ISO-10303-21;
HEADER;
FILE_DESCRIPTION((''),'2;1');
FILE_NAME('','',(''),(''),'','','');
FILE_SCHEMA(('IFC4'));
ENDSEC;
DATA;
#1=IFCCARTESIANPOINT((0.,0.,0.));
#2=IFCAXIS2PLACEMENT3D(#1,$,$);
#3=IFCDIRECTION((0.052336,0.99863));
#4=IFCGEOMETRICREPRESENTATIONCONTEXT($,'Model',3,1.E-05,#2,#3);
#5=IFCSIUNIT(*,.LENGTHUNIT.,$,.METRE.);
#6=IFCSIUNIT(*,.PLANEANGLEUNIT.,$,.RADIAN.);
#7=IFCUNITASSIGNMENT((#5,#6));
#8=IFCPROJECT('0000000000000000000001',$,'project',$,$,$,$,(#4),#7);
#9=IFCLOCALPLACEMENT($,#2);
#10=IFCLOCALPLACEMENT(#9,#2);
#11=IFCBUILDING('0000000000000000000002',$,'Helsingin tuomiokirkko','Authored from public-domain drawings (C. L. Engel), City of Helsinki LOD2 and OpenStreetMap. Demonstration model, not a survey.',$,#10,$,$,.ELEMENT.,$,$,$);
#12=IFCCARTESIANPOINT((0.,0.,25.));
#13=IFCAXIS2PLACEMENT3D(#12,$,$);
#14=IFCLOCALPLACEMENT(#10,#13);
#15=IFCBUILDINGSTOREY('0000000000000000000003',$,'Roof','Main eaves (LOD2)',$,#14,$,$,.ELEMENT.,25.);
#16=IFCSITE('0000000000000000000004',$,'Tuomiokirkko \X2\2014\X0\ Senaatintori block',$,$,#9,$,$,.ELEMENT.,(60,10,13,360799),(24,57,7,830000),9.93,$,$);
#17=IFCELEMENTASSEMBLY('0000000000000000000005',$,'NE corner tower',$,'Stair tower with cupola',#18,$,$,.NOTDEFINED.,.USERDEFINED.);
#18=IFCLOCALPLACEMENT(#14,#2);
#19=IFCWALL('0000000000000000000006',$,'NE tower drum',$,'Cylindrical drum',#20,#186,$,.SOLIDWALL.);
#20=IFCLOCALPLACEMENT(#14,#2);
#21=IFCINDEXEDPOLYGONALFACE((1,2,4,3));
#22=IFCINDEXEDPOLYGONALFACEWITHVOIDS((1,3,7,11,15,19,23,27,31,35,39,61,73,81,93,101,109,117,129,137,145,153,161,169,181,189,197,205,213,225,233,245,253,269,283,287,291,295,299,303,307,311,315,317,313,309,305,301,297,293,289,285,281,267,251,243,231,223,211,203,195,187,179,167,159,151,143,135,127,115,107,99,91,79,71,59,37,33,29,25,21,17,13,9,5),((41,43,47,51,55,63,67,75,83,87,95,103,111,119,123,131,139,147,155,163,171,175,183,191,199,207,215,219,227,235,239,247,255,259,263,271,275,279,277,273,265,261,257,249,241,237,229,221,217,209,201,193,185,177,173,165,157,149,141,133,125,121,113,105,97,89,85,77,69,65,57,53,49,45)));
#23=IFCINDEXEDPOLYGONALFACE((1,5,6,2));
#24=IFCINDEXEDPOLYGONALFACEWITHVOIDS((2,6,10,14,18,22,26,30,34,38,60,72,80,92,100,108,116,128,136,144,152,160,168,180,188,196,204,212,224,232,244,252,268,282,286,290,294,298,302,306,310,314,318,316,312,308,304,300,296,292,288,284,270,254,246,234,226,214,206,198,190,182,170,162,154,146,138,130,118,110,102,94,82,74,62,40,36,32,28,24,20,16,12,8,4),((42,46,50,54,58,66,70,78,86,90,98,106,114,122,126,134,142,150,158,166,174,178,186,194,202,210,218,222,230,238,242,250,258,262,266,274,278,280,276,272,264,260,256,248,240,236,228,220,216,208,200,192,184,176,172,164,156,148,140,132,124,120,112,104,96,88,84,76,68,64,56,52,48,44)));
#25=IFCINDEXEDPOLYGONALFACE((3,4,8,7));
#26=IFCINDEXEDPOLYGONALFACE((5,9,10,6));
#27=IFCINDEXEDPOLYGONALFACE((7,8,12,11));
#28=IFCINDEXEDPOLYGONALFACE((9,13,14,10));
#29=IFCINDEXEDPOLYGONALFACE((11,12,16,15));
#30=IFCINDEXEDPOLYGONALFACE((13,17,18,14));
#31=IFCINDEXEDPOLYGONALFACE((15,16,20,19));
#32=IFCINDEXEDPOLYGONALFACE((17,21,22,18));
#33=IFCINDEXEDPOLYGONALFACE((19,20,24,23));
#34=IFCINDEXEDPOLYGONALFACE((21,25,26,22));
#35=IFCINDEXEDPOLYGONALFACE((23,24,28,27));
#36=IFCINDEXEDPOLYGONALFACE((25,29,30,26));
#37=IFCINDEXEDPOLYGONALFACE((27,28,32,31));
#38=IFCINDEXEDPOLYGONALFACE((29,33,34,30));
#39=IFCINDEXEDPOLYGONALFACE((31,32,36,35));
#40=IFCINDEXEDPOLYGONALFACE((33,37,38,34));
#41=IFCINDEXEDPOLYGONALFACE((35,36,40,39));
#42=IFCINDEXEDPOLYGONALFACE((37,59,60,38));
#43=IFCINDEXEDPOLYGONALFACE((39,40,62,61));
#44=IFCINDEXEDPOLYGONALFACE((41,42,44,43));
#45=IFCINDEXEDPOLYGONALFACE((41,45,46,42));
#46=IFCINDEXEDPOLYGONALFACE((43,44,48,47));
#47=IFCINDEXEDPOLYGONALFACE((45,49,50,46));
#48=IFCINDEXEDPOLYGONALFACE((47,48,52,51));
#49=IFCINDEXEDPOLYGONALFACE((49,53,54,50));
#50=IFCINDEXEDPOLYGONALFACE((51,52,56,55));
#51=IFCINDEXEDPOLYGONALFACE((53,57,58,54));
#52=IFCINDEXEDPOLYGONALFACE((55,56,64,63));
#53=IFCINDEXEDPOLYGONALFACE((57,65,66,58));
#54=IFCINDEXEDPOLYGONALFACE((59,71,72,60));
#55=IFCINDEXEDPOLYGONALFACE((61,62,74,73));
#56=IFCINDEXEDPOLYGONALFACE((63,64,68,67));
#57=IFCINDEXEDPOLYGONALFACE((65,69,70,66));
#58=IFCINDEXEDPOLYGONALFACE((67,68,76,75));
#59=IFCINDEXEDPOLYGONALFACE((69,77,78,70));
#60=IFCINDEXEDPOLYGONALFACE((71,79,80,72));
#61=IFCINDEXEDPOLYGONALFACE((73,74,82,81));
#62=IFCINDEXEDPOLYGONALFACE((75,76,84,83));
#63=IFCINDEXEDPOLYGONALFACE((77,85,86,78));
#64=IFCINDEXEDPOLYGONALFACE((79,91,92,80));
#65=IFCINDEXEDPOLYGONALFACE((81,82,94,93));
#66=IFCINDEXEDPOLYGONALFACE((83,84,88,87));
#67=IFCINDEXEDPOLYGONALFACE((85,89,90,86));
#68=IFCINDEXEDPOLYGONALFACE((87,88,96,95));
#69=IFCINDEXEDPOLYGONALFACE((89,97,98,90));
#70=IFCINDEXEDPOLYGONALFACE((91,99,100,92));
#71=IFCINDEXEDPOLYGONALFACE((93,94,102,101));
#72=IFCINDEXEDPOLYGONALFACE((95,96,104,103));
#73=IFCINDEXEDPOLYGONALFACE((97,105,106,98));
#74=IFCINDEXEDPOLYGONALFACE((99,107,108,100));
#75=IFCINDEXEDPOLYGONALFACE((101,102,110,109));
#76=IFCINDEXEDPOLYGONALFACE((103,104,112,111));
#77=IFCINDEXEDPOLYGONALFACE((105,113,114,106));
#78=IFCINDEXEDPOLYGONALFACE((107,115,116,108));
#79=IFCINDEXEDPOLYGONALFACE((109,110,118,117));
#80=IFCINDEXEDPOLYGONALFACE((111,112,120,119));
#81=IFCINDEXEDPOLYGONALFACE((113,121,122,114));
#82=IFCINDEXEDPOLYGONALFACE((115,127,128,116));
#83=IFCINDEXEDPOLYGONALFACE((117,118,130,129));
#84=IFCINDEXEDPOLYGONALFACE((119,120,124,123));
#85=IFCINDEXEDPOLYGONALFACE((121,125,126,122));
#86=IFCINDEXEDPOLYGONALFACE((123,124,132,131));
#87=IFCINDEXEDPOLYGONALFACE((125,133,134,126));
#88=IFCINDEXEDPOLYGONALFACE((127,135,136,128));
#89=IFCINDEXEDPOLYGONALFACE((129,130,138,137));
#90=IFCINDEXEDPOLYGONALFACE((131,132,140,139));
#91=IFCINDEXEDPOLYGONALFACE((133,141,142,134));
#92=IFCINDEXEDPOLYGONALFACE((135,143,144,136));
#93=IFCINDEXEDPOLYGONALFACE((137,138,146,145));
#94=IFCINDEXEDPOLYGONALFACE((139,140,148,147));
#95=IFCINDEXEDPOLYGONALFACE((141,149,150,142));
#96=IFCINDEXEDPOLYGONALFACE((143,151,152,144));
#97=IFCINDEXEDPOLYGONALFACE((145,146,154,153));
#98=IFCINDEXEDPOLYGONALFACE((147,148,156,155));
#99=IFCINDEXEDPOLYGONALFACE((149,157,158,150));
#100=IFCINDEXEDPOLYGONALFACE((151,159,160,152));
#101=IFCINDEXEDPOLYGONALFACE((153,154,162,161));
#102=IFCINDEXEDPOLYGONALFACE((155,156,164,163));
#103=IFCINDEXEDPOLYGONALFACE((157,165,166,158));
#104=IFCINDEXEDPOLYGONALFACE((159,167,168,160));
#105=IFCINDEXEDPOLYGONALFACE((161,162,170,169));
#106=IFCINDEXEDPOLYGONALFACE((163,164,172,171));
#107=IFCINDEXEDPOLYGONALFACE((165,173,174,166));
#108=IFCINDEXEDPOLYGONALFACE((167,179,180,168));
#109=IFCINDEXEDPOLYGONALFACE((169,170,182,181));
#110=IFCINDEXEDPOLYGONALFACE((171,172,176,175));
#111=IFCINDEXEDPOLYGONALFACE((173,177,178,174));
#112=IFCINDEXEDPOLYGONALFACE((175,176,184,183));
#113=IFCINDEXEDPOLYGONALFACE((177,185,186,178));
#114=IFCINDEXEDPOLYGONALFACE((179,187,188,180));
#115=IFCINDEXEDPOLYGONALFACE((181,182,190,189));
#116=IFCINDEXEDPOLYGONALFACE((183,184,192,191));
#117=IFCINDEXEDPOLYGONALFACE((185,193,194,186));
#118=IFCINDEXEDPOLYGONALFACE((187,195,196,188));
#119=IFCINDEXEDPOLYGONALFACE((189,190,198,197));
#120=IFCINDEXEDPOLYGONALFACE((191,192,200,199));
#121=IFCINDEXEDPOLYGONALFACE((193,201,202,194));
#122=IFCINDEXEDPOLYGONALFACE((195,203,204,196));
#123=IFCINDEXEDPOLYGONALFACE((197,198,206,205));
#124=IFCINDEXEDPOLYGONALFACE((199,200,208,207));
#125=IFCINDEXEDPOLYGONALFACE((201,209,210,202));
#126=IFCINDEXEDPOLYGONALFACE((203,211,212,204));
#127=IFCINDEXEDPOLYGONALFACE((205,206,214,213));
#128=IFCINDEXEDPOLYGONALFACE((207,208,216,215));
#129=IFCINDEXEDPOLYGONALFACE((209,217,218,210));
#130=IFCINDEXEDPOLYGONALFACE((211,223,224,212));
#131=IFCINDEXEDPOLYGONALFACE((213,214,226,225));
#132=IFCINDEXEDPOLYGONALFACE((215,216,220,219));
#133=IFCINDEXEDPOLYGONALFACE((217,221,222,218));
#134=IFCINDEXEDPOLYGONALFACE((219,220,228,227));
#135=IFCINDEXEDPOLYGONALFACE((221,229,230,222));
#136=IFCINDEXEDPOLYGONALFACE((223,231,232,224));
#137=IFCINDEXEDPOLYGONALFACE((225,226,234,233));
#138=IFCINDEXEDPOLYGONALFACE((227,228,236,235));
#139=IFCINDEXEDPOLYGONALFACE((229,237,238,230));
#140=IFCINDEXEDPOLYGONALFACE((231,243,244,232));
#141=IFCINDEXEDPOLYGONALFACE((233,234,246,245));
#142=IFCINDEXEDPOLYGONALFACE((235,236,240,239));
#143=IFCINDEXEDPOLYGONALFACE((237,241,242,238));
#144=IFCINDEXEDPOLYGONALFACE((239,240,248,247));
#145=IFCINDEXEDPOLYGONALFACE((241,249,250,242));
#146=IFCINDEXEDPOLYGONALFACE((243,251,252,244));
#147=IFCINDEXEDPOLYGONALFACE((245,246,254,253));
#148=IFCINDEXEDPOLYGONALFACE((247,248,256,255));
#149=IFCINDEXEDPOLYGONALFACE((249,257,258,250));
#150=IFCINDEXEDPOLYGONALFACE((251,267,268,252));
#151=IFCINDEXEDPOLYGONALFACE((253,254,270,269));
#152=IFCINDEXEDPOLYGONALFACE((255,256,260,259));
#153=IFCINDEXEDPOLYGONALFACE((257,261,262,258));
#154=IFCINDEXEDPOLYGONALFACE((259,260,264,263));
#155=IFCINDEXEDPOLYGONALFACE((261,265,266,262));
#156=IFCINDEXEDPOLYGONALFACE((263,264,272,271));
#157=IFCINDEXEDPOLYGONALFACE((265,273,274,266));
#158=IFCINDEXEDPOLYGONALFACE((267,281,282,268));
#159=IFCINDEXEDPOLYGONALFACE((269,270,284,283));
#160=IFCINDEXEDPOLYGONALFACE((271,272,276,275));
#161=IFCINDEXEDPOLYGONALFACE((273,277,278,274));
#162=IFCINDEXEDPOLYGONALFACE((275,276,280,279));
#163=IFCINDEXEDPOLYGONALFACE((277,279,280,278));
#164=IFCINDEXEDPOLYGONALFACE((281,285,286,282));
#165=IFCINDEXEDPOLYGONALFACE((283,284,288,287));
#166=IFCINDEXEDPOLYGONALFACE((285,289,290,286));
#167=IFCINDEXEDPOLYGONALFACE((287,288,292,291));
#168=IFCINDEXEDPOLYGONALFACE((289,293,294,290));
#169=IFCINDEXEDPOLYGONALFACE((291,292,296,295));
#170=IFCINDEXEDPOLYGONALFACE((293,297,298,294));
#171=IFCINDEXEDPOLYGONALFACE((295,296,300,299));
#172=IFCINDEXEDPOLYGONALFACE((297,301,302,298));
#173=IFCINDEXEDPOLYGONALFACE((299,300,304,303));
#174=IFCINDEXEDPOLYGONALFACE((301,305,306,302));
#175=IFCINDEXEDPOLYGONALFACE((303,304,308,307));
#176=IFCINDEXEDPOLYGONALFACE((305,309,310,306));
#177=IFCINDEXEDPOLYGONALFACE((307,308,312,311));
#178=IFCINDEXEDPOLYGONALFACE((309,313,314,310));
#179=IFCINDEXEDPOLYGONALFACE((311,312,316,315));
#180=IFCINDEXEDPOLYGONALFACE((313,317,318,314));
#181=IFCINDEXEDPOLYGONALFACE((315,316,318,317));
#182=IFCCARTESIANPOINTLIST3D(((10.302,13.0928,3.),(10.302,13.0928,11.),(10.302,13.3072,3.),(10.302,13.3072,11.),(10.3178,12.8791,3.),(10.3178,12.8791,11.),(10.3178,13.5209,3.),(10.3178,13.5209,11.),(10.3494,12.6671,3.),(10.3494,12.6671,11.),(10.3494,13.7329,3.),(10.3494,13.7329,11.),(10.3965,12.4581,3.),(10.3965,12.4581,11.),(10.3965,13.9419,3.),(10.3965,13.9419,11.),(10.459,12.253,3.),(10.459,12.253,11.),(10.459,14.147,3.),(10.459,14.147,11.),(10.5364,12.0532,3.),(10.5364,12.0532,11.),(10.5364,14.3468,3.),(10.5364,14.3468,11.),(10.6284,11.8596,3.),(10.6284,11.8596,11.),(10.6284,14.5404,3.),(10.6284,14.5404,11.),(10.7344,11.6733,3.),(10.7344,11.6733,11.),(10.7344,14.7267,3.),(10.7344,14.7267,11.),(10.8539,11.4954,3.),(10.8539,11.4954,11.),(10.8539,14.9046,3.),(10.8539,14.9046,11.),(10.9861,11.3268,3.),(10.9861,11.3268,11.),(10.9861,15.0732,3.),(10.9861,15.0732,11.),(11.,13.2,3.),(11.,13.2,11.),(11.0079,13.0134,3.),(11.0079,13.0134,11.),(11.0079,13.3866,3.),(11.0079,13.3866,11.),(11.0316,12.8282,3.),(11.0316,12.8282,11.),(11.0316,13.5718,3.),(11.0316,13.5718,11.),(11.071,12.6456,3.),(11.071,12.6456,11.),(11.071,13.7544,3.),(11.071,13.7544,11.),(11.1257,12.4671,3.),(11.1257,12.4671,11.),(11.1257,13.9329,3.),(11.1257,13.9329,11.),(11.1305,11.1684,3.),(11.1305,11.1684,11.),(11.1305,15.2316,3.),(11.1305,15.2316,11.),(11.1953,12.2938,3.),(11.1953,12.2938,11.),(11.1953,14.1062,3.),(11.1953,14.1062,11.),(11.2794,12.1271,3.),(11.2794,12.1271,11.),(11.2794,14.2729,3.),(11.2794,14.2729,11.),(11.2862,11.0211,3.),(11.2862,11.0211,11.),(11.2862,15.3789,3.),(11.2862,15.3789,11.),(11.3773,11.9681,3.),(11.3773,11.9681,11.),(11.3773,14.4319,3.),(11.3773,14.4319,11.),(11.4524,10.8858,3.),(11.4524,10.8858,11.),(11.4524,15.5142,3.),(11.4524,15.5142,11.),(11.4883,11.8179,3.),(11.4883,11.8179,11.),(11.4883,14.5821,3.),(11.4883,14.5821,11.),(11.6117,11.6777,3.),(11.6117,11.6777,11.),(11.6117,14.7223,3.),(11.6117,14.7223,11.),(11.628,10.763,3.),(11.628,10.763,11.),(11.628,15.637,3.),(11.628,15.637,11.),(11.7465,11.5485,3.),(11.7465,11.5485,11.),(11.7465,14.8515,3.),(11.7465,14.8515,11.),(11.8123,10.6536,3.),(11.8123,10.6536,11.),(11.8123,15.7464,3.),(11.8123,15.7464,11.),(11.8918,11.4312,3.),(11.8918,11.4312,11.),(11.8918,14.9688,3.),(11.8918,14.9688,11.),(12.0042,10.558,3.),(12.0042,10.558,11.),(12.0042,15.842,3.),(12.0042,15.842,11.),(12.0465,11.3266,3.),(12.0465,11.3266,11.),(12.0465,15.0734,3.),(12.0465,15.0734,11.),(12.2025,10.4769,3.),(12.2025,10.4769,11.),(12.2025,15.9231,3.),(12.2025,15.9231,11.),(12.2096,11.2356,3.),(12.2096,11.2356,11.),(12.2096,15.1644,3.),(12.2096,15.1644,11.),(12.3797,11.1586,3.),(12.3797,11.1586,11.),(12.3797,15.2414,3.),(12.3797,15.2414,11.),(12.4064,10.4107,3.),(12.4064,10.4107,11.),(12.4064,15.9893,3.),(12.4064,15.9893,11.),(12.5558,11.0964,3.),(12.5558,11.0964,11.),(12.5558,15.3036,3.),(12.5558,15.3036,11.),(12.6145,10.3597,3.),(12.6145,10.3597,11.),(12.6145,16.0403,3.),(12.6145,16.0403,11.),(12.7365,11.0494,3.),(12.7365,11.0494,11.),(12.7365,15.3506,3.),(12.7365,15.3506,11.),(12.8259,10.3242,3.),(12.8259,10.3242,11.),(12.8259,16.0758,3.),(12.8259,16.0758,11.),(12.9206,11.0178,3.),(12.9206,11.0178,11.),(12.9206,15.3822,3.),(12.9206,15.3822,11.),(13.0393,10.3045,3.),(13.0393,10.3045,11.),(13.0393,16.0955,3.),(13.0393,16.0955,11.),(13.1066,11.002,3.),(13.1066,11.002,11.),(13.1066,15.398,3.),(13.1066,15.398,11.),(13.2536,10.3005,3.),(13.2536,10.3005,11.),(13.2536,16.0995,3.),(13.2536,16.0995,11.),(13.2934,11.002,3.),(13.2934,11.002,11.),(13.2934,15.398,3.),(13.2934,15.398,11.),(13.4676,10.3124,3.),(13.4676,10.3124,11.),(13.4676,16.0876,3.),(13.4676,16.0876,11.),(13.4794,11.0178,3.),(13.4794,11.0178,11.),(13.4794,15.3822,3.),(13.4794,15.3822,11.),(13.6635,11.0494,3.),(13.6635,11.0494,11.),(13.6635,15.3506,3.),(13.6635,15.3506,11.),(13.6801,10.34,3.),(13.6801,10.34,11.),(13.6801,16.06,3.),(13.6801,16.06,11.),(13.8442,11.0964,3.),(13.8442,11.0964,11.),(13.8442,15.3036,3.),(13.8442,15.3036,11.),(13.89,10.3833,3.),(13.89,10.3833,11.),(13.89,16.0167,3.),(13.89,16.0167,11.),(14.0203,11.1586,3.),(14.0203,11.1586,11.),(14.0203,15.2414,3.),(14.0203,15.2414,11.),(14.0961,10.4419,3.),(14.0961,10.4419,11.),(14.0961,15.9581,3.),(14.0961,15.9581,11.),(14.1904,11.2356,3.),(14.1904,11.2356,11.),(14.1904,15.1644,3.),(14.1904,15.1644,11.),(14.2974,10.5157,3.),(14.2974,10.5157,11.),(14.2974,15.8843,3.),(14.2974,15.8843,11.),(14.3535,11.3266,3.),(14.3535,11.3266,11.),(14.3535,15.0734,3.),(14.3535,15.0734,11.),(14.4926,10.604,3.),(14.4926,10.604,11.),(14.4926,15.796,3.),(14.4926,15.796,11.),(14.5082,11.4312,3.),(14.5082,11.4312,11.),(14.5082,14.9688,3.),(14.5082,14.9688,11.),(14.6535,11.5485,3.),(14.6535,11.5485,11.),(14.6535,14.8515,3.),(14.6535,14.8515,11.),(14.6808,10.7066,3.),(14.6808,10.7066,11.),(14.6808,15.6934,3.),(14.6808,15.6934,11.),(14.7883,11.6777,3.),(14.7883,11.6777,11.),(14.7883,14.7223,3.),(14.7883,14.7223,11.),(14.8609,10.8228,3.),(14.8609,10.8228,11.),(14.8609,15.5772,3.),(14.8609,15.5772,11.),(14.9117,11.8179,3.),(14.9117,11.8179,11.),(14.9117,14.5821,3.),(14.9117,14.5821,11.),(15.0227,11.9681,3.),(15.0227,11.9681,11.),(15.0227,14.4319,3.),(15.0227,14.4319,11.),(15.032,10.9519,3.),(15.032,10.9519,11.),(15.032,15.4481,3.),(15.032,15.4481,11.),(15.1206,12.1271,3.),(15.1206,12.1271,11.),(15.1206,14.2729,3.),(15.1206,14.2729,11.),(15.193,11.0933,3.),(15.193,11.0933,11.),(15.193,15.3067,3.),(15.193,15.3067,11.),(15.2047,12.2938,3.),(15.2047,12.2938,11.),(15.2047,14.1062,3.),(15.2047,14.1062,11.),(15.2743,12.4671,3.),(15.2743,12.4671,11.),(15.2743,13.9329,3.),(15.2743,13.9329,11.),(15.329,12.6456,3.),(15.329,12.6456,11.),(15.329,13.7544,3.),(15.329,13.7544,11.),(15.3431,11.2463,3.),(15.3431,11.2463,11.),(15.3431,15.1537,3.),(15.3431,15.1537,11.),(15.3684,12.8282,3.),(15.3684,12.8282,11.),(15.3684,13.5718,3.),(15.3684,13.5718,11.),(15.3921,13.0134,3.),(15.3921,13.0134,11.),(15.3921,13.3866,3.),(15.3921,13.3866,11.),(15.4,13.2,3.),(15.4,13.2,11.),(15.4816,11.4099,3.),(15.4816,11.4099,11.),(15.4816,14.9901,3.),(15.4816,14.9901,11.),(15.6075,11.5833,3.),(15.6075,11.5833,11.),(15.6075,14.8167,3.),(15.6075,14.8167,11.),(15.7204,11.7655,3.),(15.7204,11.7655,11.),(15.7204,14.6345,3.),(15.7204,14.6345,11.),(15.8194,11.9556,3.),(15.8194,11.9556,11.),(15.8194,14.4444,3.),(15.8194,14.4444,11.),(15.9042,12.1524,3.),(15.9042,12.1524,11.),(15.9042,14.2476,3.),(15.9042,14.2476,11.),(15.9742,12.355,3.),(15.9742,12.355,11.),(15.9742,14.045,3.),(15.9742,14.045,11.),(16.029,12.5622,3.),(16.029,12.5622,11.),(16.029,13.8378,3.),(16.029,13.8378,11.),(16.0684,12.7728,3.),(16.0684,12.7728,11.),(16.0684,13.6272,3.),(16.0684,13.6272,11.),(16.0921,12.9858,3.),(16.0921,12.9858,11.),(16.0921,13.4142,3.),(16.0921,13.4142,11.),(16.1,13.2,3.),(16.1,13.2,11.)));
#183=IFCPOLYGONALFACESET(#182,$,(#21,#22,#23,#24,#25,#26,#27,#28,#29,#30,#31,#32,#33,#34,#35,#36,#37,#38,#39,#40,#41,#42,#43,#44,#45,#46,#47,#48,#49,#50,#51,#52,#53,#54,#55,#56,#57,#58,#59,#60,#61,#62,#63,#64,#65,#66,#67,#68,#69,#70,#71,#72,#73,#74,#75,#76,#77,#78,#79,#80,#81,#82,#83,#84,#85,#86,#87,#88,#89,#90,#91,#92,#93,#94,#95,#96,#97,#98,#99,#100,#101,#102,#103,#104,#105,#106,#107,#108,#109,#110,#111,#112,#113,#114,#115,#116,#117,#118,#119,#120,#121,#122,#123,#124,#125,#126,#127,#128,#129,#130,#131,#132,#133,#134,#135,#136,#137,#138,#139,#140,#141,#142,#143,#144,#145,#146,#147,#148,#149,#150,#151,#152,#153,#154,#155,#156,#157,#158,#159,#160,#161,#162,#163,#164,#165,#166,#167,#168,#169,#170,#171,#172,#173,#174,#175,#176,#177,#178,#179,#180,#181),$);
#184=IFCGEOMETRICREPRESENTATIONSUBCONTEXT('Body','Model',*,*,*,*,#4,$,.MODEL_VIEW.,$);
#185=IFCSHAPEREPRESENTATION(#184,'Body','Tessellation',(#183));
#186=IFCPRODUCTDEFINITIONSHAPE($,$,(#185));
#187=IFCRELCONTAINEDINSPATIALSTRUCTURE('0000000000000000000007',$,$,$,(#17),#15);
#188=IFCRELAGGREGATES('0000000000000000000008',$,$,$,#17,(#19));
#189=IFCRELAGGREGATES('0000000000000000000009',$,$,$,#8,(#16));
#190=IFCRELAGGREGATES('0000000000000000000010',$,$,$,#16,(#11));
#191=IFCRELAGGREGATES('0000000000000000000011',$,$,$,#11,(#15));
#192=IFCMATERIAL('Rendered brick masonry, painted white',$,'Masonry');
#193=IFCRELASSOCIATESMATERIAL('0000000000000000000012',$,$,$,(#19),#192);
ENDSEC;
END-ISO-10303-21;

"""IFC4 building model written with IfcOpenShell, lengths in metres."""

from ifc_helpers import new_model, si_unit, direction, frame, origin, origin_2d_with_axis, place, context, subcontext, project, spatial, hollow_circle, extrude, material, element, aggregate, save


model = new_model("IFC4")

# Units and contexts
model_context = context("Model", 3, precision=1e-05, world=origin(), true_north=direction((0.052336, 0.99863)))
body_context = subcontext(model_context, "Body", "Model", "MODEL_VIEW")
ifc_project = project(units=[si_unit("LENGTHUNIT", "METRE"), si_unit("PLANEANGLEUNIT", "RADIAN")], contexts=[model_context])

# Site, building, storey
site_placement = place(None, origin())
site = spatial("IfcSite", under=ifc_project, at=site_placement, Name="Tuomiokirkko — Senaatintori block", CompositionType="ELEMENT", RefLatitude=(60, 10, 13, 360799), RefLongitude=(24, 57, 7, 830000), RefElevation=9.93)
building_placement = place(site_placement, origin())
building = spatial("IfcBuilding", under=site, at=building_placement, Name="Helsingin tuomiokirkko", Description="Authored from public-domain drawings (C. L. Engel), City of Helsinki LOD2 and OpenStreetMap. Demonstration model, not a survey.", CompositionType="ELEMENT")
storey_placement = place(building_placement, frame((0.0, 0.0, 25.0)))
storey = spatial("IfcBuildingStorey", under=building, at=storey_placement, Name="Roof", Description="Main eaves (LOD2)", CompositionType="ELEMENT", Elevation=25.0)

# Element assembly
assembly_1_placement = place(building_placement, origin())
assembly_1 = element("IfcElementAssembly", 1, at=assembly_1_placement, inside=storey, Name="NE corner tower", ObjectType="Stair tower with cupola", AssemblyPlace="NOTDEFINED", PredefinedType="USERDEFINED")

# Shared definitions
ifc_material_1 = material(Name="Rendered brick masonry, painted white", Category="Masonry")

# Wall
wall_1_placement = place(building_placement, origin())
wall_1 = element("IfcWall", 2, at=wall_1_placement, material=ifc_material_1, Name="NE tower drum", ObjectType="Cylindrical drum", PredefinedType="SOLIDWALL", context=body_context, shape_type="SweptSolid", body=[
    extrude(hollow_circle(Radius=2.9, WallThickness=0.7, at=origin_2d_with_axis()), frame((13.2, 13.2, 28.0)), (0.0, 0.0, 1.0), 8.0),
])

aggregate(assembly_1, [wall_1])

save(model, "model.ifc")
